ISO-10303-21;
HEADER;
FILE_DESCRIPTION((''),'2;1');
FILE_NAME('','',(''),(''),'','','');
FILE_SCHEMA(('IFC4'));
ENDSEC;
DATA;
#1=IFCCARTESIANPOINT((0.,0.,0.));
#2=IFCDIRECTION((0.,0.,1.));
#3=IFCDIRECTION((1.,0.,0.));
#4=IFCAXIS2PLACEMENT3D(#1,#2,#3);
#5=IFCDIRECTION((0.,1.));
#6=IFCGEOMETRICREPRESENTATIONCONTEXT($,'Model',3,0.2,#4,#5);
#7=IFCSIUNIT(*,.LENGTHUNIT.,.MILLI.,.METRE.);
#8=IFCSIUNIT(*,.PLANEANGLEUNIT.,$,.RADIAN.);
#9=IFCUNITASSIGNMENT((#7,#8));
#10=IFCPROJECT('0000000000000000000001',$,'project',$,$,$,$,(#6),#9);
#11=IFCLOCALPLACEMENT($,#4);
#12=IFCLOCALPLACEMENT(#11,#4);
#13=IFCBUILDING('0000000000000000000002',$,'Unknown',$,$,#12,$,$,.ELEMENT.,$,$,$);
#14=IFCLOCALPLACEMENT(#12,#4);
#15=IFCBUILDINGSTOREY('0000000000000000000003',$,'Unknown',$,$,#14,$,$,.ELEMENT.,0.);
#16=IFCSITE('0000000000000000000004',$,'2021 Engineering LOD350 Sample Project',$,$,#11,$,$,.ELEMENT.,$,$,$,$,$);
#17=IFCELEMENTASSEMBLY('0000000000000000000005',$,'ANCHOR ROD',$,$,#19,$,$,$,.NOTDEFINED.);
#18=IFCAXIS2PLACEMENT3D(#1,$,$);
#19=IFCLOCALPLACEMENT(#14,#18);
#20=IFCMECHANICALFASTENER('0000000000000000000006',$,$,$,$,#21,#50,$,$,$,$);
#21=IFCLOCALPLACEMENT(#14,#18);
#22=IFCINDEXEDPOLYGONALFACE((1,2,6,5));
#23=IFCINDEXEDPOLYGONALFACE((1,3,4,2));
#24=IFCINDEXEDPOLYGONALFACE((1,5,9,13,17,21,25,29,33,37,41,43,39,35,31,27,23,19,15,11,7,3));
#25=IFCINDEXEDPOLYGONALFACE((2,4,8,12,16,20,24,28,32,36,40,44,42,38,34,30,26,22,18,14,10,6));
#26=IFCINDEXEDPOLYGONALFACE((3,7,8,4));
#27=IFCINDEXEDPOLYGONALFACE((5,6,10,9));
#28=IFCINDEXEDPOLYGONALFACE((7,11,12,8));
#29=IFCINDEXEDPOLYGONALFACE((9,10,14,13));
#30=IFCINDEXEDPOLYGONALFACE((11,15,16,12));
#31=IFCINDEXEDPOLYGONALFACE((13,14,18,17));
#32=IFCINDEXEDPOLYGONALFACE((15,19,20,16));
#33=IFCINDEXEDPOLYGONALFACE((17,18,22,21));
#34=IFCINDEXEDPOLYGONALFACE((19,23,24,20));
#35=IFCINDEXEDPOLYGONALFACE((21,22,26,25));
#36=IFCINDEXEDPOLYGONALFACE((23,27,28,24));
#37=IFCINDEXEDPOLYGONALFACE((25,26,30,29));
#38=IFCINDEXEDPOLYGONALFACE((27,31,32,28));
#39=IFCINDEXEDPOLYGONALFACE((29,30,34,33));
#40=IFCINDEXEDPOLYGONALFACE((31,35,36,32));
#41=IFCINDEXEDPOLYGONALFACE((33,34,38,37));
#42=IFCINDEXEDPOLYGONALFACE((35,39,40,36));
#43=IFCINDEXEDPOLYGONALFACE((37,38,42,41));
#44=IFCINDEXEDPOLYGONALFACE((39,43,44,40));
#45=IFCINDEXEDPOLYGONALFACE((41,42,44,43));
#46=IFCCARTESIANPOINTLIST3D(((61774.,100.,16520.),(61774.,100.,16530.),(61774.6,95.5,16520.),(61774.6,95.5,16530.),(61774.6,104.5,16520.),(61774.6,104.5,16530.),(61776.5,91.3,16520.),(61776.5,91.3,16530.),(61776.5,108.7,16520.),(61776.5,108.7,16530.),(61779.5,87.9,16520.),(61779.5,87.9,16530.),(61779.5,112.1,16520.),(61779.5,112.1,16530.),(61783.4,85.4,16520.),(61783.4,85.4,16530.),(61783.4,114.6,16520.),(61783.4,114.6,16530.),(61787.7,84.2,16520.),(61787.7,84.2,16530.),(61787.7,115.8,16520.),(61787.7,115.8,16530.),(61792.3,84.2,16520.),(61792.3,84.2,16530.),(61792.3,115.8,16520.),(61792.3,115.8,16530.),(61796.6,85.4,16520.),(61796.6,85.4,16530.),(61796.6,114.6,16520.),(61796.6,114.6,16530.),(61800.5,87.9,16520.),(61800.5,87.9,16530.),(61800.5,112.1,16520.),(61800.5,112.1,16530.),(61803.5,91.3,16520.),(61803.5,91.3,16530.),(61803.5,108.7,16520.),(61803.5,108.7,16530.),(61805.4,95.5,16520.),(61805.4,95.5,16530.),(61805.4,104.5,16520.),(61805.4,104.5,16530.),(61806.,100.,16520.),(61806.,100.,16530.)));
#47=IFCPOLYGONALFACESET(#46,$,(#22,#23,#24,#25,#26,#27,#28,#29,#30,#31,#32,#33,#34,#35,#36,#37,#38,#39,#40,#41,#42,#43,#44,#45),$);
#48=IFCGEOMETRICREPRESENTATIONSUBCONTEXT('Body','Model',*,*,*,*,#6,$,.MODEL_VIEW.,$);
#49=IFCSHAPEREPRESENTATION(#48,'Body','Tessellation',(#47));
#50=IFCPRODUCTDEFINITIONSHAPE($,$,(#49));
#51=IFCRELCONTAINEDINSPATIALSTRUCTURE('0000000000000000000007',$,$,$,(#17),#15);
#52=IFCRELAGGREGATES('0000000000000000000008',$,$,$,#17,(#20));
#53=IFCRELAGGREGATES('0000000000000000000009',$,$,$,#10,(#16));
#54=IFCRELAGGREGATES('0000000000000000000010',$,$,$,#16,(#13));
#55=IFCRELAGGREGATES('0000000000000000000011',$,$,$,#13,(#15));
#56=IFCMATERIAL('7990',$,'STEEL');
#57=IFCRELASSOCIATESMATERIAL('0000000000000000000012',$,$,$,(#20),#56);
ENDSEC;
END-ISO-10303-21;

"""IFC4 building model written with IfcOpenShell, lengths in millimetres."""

from ifc_helpers import new_model, si_unit, direction, frame, origin_with_axes, place, context, subcontext, project, spatial, arc, indexed_curve, outline, extrude, source, transform, mapped, material, element, aggregate, save


model = new_model("IFC4")

# Units and contexts
model_context = context("Model", 3, precision=0.2, world=origin_with_axes(), true_north=direction((0.0, 1.0)))
body_context = subcontext(model_context, "Body", "Model", "MODEL_VIEW")
ifc_project = project(units=[si_unit("LENGTHUNIT", "METRE", prefix="MILLI"), si_unit("PLANEANGLEUNIT", "RADIAN")], contexts=[model_context])

# Site, building, storey
site_placement = place(None, origin_with_axes())
site = spatial("IfcSite", under=ifc_project, at=site_placement, Name="2021 Engineering LOD350 Sample Project", CompositionType="ELEMENT")
building_placement = place(site_placement, origin_with_axes())
building = spatial("IfcBuilding", under=site, at=building_placement, Name="Unknown", CompositionType="ELEMENT")
storey_placement = place(building_placement, origin_with_axes())
storey = spatial("IfcBuildingStorey", under=building, at=storey_placement, Name="Unknown", CompositionType="ELEMENT", Elevation=0.0)

# Element assembly
assembly_1_placement = place(storey_placement, frame((61790.0, 100.0, 16730.0), z_axis=(1.0, 0.0, 0.0), x_axis=(0.0, 0.0, -1.0)))
assembly_1 = element("IfcElementAssembly", 1, at=assembly_1_placement, inside=storey, Name="ANCHOR ROD", PredefinedType="NOTDEFINED")

# Shared definitions
ifc_material_1 = material(Name="7990", Category="STEEL")

# Mechanical fastener
shared_shape_1 = source(origin_with_axes(), body_context, "Body", "SweptSolid", [
    extrude(outline(indexed_curve([(16.0, 0.0), (0.0, 16.0), (-16.0, 0.0), (0.0, -16.0)], segments=[arc(1, 2, 3), arc(3, 4, 1)])), frame((0.0, 0.0, 0.0), z_axis=(0.0, 0.0, -1.0), x_axis=(0.0, 1.0, 0.0)), (0.0, 0.0, 1.0), 10.0),
])
mechanical_fastener_1_placement = place(assembly_1_placement, frame((210.0, 0.0, 0.0), z_axis=(1.0, 0.0, 0.0), x_axis=(0.0, 1.0, 0.0)))
mechanical_fastener_1 = element("IfcMechanicalFastener", 2, at=mechanical_fastener_1_placement, material=ifc_material_1, context=body_context, shape_type="MappedRepresentation", body=[
    mapped(shared_shape_1, transform((0.0, 0.0, 0.0))),
])
aggregate(assembly_1, [mechanical_fastener_1])

save(model, "model.ifc")
